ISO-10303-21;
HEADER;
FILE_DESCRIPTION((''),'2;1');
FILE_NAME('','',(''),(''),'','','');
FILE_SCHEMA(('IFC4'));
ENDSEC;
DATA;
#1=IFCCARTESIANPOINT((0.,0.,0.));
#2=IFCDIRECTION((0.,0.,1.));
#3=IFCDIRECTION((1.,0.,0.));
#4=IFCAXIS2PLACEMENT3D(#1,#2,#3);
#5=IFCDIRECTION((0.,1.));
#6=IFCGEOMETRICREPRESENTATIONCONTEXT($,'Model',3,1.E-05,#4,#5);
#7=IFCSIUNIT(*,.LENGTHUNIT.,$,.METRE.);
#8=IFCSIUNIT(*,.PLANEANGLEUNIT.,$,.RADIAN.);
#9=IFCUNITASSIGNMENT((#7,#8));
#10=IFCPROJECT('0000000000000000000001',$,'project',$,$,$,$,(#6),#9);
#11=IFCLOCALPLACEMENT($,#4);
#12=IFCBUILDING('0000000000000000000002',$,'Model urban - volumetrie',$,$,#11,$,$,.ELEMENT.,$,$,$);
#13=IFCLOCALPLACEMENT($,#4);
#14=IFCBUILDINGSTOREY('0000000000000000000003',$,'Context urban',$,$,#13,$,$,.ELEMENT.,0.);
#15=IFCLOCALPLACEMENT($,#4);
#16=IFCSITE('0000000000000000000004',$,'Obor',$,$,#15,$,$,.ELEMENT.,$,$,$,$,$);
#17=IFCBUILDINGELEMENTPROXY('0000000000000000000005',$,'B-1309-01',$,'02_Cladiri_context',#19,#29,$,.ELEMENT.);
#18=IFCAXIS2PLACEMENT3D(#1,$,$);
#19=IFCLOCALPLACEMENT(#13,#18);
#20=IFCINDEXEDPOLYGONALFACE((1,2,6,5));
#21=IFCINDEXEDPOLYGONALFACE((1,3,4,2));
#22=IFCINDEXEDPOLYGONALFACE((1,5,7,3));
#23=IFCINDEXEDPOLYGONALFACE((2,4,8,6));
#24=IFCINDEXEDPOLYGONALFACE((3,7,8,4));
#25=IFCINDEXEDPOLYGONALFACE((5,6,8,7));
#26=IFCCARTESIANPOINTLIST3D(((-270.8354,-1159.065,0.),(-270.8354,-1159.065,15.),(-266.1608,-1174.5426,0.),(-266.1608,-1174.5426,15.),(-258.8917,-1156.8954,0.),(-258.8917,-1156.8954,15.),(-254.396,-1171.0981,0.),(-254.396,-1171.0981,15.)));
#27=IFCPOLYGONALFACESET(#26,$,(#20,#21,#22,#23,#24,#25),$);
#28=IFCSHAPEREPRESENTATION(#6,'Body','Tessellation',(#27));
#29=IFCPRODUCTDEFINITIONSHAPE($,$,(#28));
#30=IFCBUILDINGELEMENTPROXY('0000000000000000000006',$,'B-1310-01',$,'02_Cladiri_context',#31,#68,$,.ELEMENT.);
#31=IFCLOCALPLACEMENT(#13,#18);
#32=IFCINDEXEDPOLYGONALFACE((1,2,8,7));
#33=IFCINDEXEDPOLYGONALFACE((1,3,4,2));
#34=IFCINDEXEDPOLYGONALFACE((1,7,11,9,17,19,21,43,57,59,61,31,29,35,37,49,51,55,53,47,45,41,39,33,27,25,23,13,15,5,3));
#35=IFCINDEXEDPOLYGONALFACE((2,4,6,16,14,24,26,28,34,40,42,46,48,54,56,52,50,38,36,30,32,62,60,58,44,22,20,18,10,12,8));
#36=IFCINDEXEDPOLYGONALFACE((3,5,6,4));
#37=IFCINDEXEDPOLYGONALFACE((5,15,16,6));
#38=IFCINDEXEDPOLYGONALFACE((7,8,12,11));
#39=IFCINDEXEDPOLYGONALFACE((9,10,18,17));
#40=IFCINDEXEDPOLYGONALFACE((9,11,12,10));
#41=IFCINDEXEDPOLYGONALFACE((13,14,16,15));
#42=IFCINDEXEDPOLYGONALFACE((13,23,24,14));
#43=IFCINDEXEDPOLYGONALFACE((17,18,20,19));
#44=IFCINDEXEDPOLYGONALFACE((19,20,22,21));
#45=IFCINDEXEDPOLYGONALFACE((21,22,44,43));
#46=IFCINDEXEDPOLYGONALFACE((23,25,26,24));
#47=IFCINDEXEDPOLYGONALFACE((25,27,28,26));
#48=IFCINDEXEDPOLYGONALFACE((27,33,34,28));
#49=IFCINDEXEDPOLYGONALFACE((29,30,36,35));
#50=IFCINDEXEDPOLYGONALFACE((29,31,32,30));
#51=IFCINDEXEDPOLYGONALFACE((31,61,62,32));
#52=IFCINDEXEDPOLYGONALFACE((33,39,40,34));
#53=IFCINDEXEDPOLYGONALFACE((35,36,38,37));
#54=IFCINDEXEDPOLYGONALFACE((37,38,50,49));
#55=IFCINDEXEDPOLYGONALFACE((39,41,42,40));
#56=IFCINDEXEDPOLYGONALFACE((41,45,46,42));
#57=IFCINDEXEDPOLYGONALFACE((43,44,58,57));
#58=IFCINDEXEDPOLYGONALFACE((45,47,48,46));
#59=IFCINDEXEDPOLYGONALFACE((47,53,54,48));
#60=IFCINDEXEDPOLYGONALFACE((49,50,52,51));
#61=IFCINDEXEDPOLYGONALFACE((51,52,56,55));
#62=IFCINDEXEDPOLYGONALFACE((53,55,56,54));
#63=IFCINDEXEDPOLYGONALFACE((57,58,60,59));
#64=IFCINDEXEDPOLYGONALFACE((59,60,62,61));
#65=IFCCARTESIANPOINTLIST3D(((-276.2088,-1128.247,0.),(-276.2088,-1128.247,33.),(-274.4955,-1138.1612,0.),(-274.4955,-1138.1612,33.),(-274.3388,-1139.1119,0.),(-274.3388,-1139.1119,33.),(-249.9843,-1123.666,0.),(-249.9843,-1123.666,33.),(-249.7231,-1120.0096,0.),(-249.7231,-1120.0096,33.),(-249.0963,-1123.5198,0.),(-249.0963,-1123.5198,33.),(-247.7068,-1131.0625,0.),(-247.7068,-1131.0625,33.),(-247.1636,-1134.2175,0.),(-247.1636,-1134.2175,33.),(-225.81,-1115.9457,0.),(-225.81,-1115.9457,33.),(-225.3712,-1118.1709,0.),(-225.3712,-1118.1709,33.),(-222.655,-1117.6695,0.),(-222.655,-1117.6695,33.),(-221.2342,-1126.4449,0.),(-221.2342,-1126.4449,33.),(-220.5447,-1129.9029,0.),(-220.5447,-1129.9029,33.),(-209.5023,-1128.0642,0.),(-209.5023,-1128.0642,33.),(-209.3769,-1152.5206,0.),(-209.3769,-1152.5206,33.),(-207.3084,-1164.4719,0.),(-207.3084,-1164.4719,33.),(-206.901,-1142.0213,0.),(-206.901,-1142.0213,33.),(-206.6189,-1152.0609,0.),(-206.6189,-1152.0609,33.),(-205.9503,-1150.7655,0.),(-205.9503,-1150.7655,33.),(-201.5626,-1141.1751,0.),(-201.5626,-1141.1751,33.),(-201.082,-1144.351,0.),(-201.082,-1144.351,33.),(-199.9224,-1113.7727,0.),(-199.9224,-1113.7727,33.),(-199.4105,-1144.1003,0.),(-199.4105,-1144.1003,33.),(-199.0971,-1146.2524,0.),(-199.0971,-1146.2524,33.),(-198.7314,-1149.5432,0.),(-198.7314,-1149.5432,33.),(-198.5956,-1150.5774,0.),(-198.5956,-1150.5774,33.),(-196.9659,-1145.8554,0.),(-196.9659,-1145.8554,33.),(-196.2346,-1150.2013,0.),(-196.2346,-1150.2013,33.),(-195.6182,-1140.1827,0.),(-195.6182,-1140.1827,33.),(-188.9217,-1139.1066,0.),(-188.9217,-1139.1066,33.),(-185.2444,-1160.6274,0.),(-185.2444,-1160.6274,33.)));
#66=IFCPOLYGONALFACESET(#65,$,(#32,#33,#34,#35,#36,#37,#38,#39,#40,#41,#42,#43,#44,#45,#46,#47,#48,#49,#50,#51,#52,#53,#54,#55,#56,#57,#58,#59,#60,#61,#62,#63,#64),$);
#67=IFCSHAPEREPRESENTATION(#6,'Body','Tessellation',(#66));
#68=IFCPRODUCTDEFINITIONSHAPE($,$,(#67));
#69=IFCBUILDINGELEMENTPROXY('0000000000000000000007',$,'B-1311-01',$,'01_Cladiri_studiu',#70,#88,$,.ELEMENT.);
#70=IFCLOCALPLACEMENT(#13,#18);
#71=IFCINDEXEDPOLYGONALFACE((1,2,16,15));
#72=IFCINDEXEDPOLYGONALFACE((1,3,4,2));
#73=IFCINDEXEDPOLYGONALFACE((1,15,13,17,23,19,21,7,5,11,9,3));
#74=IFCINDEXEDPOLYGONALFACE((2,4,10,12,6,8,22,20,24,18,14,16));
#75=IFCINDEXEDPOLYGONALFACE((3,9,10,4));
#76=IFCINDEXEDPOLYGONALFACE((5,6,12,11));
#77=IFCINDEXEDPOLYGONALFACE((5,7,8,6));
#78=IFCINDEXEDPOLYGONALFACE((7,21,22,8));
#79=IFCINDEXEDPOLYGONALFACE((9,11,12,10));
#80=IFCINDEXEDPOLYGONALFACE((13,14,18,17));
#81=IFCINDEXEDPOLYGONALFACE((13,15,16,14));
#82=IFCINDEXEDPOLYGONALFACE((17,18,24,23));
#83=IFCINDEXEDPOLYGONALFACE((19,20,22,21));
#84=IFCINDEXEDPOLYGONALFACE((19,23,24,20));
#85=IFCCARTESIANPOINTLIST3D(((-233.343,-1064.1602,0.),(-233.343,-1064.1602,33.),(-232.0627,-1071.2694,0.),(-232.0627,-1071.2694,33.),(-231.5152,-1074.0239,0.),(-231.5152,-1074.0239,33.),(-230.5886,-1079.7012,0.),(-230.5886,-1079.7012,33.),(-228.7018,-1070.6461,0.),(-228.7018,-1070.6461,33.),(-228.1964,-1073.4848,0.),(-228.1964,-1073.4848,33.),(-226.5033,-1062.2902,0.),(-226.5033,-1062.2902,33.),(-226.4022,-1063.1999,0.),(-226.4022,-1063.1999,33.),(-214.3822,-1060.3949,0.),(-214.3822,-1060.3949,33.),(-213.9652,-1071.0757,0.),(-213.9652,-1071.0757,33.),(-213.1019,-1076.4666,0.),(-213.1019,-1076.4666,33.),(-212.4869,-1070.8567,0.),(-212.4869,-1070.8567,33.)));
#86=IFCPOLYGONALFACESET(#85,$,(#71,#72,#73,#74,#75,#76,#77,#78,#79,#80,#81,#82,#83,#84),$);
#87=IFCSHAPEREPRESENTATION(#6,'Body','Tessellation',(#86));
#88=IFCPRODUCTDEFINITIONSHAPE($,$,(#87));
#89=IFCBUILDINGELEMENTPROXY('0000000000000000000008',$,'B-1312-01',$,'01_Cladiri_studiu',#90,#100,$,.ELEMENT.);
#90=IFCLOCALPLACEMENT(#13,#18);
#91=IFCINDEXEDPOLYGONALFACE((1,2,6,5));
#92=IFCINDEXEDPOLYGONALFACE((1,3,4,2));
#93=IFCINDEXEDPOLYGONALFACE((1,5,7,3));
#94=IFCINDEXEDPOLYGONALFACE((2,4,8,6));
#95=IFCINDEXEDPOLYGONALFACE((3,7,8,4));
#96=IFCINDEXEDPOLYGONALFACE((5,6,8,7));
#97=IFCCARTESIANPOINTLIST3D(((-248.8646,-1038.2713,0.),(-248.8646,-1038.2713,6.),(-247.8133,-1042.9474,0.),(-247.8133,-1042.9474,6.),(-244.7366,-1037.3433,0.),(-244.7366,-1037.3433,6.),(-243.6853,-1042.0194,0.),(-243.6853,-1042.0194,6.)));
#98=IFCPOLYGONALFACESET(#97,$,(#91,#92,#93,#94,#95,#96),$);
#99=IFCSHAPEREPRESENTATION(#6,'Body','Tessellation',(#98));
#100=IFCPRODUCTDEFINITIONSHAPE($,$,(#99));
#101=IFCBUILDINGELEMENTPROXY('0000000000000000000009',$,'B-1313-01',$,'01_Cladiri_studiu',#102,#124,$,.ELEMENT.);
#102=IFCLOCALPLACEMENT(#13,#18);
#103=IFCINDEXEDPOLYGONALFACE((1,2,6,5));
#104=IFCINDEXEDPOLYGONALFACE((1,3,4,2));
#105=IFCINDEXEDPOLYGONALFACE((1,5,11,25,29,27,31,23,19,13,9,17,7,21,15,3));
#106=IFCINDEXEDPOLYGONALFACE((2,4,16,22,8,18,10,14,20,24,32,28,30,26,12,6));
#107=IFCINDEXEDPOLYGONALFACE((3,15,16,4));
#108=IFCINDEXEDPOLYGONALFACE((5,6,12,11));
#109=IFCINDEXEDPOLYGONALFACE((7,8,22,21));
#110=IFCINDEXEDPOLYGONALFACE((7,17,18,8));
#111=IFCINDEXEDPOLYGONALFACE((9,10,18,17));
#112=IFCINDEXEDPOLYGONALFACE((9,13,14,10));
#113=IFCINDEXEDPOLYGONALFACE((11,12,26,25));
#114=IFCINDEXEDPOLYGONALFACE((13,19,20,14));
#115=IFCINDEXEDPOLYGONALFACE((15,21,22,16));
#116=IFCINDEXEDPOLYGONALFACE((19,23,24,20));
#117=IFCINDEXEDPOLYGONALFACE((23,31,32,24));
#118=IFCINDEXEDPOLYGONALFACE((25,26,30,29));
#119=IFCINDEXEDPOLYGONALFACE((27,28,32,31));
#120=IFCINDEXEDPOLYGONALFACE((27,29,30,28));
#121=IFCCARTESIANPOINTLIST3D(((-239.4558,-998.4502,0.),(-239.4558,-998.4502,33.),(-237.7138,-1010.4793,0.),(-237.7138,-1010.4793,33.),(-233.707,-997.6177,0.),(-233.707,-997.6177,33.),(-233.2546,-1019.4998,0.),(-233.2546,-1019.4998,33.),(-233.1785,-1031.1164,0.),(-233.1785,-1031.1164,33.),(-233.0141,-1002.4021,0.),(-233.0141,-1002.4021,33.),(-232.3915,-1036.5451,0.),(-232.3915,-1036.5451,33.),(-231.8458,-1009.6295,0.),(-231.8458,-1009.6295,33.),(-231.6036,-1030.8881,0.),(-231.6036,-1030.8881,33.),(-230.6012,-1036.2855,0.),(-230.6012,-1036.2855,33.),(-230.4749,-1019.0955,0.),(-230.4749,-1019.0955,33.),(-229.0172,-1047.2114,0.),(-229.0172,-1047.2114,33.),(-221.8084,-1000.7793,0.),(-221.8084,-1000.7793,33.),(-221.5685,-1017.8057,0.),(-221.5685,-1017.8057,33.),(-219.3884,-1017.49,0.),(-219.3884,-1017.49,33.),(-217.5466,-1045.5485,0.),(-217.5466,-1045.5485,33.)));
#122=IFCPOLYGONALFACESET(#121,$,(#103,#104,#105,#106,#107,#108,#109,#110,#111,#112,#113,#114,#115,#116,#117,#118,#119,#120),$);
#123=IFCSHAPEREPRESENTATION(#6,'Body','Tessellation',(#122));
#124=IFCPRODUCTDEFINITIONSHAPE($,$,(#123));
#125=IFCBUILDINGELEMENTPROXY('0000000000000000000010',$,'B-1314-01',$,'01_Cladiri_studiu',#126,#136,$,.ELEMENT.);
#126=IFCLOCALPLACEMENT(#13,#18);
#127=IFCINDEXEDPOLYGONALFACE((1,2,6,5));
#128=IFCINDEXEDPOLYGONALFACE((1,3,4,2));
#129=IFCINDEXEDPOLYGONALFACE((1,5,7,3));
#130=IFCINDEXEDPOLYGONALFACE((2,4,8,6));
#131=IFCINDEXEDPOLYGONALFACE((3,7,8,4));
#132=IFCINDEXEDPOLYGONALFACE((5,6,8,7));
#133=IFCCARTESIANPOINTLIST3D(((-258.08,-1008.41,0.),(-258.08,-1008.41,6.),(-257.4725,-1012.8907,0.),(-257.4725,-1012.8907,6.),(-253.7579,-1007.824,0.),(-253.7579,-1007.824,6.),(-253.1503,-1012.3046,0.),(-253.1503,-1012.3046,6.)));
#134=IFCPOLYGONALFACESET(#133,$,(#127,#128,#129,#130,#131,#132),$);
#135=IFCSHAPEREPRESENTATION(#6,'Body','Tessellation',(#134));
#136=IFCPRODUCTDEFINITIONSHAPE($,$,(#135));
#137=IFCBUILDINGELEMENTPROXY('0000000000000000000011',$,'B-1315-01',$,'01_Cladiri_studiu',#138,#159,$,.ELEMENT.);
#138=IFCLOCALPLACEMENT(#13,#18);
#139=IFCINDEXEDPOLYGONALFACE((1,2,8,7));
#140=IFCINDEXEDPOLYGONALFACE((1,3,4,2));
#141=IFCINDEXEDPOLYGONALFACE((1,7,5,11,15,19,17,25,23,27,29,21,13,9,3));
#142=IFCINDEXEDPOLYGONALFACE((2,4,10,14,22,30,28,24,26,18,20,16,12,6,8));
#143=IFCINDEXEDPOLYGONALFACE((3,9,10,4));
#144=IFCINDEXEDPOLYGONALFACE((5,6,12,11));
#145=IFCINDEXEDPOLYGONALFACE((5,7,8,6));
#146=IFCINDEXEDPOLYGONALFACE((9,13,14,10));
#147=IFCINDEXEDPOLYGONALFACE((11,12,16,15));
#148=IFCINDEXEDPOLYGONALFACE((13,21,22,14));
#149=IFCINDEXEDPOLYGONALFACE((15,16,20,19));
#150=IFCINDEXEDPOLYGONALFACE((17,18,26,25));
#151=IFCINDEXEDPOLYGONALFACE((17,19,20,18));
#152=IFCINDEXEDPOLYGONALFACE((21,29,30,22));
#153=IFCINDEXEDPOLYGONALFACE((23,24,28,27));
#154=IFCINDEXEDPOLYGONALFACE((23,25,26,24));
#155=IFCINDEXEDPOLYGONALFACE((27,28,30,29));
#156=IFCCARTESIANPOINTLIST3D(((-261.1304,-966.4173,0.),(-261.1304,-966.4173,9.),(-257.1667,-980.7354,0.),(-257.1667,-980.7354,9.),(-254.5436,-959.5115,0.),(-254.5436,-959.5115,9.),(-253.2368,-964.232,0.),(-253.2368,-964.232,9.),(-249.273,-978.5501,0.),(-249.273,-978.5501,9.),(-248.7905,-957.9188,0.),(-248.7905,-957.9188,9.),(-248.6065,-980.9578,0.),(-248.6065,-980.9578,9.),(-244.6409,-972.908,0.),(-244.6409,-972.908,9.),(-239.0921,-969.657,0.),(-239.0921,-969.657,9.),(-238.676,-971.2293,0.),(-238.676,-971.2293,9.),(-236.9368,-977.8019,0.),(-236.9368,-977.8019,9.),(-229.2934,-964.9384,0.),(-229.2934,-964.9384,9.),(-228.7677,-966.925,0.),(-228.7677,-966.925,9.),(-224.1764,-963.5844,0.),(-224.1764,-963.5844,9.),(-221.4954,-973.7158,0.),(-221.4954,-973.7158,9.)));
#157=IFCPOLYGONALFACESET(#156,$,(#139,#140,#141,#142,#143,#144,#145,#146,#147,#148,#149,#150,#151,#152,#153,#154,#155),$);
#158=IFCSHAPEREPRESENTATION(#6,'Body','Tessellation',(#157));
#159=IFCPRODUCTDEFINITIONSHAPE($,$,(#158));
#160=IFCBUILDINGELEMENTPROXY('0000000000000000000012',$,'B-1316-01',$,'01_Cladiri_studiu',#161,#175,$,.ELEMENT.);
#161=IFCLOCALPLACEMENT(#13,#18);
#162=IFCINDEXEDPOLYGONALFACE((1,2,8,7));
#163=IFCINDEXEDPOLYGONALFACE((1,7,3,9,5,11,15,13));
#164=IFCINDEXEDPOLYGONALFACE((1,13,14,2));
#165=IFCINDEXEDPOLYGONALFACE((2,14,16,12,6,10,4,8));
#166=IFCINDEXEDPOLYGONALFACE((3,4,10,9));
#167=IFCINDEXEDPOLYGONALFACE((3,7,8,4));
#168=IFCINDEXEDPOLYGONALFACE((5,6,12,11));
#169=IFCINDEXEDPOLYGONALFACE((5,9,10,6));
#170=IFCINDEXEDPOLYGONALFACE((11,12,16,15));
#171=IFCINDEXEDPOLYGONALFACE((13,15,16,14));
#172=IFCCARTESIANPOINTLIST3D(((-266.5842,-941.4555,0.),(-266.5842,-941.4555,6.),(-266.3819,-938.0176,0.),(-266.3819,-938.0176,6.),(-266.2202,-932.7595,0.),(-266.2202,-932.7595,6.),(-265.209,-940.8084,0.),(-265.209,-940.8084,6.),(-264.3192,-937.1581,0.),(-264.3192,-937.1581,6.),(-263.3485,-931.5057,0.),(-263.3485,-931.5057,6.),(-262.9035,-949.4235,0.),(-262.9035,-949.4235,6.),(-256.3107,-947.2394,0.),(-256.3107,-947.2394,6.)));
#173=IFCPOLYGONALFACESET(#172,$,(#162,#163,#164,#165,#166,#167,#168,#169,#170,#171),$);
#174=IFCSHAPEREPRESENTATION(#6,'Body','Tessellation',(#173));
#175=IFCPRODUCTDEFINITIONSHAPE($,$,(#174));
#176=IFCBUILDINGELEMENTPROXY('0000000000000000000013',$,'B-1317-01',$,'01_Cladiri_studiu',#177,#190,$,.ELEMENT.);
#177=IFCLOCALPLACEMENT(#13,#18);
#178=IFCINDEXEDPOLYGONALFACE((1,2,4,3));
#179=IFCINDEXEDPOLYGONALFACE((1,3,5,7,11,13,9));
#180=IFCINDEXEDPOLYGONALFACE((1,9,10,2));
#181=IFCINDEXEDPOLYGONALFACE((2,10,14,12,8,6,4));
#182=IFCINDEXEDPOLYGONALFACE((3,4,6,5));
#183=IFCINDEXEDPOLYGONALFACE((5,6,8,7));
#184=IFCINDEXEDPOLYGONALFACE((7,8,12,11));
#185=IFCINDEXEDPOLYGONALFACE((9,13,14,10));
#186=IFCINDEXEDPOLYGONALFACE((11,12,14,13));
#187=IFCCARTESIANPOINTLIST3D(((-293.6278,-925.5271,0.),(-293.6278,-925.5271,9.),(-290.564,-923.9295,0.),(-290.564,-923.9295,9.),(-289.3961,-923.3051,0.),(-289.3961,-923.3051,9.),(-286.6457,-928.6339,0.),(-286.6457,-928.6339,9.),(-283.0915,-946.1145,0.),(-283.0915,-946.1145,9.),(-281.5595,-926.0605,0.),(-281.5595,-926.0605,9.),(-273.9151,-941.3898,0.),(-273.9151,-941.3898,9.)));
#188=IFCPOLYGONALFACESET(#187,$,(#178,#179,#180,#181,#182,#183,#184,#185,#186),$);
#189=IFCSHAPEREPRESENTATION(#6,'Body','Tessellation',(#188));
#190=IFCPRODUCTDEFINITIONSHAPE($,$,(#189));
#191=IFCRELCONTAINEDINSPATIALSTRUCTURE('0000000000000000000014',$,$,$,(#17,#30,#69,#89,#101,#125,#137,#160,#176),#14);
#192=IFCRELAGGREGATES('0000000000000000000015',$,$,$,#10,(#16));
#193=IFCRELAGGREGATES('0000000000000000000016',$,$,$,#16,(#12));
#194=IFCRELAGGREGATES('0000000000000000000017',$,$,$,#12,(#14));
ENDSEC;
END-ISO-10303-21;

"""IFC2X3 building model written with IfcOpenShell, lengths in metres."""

from ifc_helpers import new_model, si_unit, direction, origin_with_axes, place, context, project, spatial, polyline, outline, extrude, element, save


model = new_model("IFC2X3")

# Units and contexts
model_context = context("Model", 3, precision=1e-05, world=origin_with_axes(), true_north=direction((0.0, 1.0)))
ifc_project = project(units=[si_unit("LENGTHUNIT", "METRE"), si_unit("PLANEANGLEUNIT", "RADIAN")], contexts=[model_context])

# Site, building, storey
site_placement = place(None, origin_with_axes())
site = spatial("IfcSite", under=ifc_project, at=site_placement, Name="Obor", CompositionType="ELEMENT")
building_placement = place(None, origin_with_axes())
building = spatial("IfcBuilding", under=site, at=building_placement, Name="Model urban - volumetrie", CompositionType="ELEMENT")
storey_placement = place(None, origin_with_axes())
storey = spatial("IfcBuildingStorey", under=building, at=storey_placement, Name="Context urban", CompositionType="ELEMENT", Elevation=0.0)

# Building element proxies
proxy_1_placement = place(None, origin_with_axes())
element("IfcBuildingElementProxy", 1, at=proxy_1_placement, inside=storey, Name="B-1309-01", ObjectType="02_Cladiri_context", CompositionType="ELEMENT", context=model_context, shape_type="SweptSolid", body=[
    extrude(outline(polyline([(-254.396, -1171.0981), (-258.8917, -1156.8954), (-270.8354, -1159.065), (-266.1608, -1174.5426), (-254.396, -1171.0981)])), origin_with_axes(), (0.0, 0.0, 1.0), 15.0),
])
proxy_2_placement = place(None, origin_with_axes())
element("IfcBuildingElementProxy", 2, at=proxy_2_placement, inside=storey, Name="B-1310-01", ObjectType="02_Cladiri_context", CompositionType="ELEMENT", context=model_context, shape_type="SweptSolid", body=[
    extrude(outline(polyline([(-195.6182, -1140.1827), (-199.9224, -1113.7727), (-222.655, -1117.6695), (-225.3712, -1118.1709), (-225.81, -1115.9457), (-249.7231, -1120.0096), (-249.0963, -1123.5198), (-249.9843, -1123.666), (-276.2088, -1128.247), (-274.4955, -1138.1612), (-274.3388, -1139.1119), (-247.1636, -1134.2175), (-247.7068, -1131.0625), (-221.2342, -1126.4449), (-220.5447, -1129.9029), (-209.5023, -1128.0642), (-206.901, -1142.0213), (-201.5626, -1141.1751), (-201.082, -1144.351), (-199.4105, -1144.1003), (-199.0971, -1146.2524), (-196.9659, -1145.8554), (-196.2346, -1150.2013), (-198.5956, -1150.5774), (-198.7314, -1149.5432), (-205.9503, -1150.7655), (-206.6189, -1152.0609), (-209.3769, -1152.5206), (-207.3084, -1164.4719), (-185.2444, -1160.6274), (-188.9217, -1139.1066), (-195.6182, -1140.1827)])), origin_with_axes(), (0.0, 0.0, 1.0), 33.0),
])
proxy_3_placement = place(None, origin_with_axes())
element("IfcBuildingElementProxy", 3, at=proxy_3_placement, inside=storey, Name="B-1311-01", ObjectType="01_Cladiri_studiu", CompositionType="ELEMENT", context=model_context, shape_type="SweptSolid", body=[
    extrude(outline(polyline([(-228.7018, -1070.6461), (-228.1964, -1073.4848), (-231.5152, -1074.0239), (-230.5886, -1079.7012), (-213.1019, -1076.4666), (-213.9652, -1071.0757), (-212.4869, -1070.8567), (-214.3822, -1060.3949), (-226.5033, -1062.2902), (-226.4022, -1063.1999), (-233.343, -1064.1602), (-232.0627, -1071.2694), (-228.7018, -1070.6461)])), origin_with_axes(), (0.0, 0.0, 1.0), 33.0),
])
proxy_4_placement = place(None, origin_with_axes())
element("IfcBuildingElementProxy", 4, at=proxy_4_placement, inside=storey, Name="B-1312-01", ObjectType="01_Cladiri_studiu", CompositionType="ELEMENT", context=model_context, shape_type="SweptSolid", body=[
    extrude(outline(polyline([(-248.8646, -1038.2713), (-247.8133, -1042.9474), (-243.6853, -1042.0194), (-244.7366, -1037.3433), (-248.8646, -1038.2713)])), origin_with_axes(), (0.0, 0.0, 1.0), 6.0),
])
proxy_5_placement = place(None, origin_with_axes())
element("IfcBuildingElementProxy", 5, at=proxy_5_placement, inside=storey, Name="B-1313-01", ObjectType="01_Cladiri_studiu", CompositionType="ELEMENT", context=model_context, shape_type="SweptSolid", body=[
    extrude(outline(polyline([(-233.0141, -1002.4021), (-233.707, -997.6177), (-239.4558, -998.4502), (-237.7138, -1010.4793), (-231.8458, -1009.6295), (-230.4749, -1019.0955), (-233.2546, -1019.4998), (-231.6036, -1030.8881), (-233.1785, -1031.1164), (-232.3915, -1036.5451), (-230.6012, -1036.2855), (-229.0172, -1047.2114), (-217.5466, -1045.5485), (-221.5685, -1017.8057), (-219.3884, -1017.49), (-221.8084, -1000.7793), (-233.0141, -1002.4021)])), origin_with_axes(), (0.0, 0.0, 1.0), 33.0),
])
proxy_6_placement = place(None, origin_with_axes())
element("IfcBuildingElementProxy", 6, at=proxy_6_placement, inside=storey, Name="B-1314-01", ObjectType="01_Cladiri_studiu", CompositionType="ELEMENT", context=model_context, shape_type="SweptSolid", body=[
    extrude(outline(polyline([(-253.1503, -1012.3046), (-253.7579, -1007.824), (-258.08, -1008.41), (-257.4725, -1012.8907), (-253.1503, -1012.3046)])), origin_with_axes(), (0.0, 0.0, 1.0), 6.0),
])
proxy_7_placement = place(None, origin_with_axes())
element("IfcBuildingElementProxy", 7, at=proxy_7_placement, inside=storey, Name="B-1315-01", ObjectType="01_Cladiri_studiu", CompositionType="ELEMENT", context=model_context, shape_type="SweptSolid", body=[
    extrude(outline(polyline([(-248.6065, -980.9578), (-236.9368, -977.8019), (-221.4954, -973.7158), (-224.1764, -963.5844), (-229.2934, -964.9384), (-228.7677, -966.925), (-239.0921, -969.657), (-238.676, -971.2293), (-244.6409, -972.908), (-248.7905, -957.9188), (-254.5436, -959.5115), (-253.2368, -964.232), (-261.1304, -966.4173), (-257.1667, -980.7354), (-249.273, -978.5501), (-248.6065, -980.9578)])), origin_with_axes(), (0.0, 0.0, 1.0), 9.0),
])
proxy_8_placement = place(None, origin_with_axes())
element("IfcBuildingElementProxy", 8, at=proxy_8_placement, inside=storey, Name="B-1316-01", ObjectType="01_Cladiri_studiu", CompositionType="ELEMENT", context=model_context, shape_type="SweptSolid", body=[
    extrude(outline(polyline([(-266.2202, -932.7595), (-264.3192, -937.1581), (-266.3819, -938.0176), (-265.209, -940.8084), (-266.5842, -941.4555), (-262.9035, -949.4235), (-256.3107, -947.2394), (-263.3485, -931.5057), (-266.2202, -932.7595)])), origin_with_axes(), (0.0, 0.0, 1.0), 6.0),
])
proxy_9_placement = place(None, origin_with_axes())
element("IfcBuildingElementProxy", 9, at=proxy_9_placement, inside=storey, Name="B-1317-01", ObjectType="01_Cladiri_studiu", CompositionType="ELEMENT", context=model_context, shape_type="SweptSolid", body=[
    extrude(outline(polyline([(-293.6278, -925.5271), (-283.0915, -946.1145), (-273.9151, -941.3898), (-281.5595, -926.0605), (-286.6457, -928.6339), (-289.3961, -923.3051), (-290.564, -923.9295), (-293.6278, -925.5271)])), origin_with_axes(), (0.0, 0.0, 1.0), 9.0),
])

save(model, "model.ifc")
